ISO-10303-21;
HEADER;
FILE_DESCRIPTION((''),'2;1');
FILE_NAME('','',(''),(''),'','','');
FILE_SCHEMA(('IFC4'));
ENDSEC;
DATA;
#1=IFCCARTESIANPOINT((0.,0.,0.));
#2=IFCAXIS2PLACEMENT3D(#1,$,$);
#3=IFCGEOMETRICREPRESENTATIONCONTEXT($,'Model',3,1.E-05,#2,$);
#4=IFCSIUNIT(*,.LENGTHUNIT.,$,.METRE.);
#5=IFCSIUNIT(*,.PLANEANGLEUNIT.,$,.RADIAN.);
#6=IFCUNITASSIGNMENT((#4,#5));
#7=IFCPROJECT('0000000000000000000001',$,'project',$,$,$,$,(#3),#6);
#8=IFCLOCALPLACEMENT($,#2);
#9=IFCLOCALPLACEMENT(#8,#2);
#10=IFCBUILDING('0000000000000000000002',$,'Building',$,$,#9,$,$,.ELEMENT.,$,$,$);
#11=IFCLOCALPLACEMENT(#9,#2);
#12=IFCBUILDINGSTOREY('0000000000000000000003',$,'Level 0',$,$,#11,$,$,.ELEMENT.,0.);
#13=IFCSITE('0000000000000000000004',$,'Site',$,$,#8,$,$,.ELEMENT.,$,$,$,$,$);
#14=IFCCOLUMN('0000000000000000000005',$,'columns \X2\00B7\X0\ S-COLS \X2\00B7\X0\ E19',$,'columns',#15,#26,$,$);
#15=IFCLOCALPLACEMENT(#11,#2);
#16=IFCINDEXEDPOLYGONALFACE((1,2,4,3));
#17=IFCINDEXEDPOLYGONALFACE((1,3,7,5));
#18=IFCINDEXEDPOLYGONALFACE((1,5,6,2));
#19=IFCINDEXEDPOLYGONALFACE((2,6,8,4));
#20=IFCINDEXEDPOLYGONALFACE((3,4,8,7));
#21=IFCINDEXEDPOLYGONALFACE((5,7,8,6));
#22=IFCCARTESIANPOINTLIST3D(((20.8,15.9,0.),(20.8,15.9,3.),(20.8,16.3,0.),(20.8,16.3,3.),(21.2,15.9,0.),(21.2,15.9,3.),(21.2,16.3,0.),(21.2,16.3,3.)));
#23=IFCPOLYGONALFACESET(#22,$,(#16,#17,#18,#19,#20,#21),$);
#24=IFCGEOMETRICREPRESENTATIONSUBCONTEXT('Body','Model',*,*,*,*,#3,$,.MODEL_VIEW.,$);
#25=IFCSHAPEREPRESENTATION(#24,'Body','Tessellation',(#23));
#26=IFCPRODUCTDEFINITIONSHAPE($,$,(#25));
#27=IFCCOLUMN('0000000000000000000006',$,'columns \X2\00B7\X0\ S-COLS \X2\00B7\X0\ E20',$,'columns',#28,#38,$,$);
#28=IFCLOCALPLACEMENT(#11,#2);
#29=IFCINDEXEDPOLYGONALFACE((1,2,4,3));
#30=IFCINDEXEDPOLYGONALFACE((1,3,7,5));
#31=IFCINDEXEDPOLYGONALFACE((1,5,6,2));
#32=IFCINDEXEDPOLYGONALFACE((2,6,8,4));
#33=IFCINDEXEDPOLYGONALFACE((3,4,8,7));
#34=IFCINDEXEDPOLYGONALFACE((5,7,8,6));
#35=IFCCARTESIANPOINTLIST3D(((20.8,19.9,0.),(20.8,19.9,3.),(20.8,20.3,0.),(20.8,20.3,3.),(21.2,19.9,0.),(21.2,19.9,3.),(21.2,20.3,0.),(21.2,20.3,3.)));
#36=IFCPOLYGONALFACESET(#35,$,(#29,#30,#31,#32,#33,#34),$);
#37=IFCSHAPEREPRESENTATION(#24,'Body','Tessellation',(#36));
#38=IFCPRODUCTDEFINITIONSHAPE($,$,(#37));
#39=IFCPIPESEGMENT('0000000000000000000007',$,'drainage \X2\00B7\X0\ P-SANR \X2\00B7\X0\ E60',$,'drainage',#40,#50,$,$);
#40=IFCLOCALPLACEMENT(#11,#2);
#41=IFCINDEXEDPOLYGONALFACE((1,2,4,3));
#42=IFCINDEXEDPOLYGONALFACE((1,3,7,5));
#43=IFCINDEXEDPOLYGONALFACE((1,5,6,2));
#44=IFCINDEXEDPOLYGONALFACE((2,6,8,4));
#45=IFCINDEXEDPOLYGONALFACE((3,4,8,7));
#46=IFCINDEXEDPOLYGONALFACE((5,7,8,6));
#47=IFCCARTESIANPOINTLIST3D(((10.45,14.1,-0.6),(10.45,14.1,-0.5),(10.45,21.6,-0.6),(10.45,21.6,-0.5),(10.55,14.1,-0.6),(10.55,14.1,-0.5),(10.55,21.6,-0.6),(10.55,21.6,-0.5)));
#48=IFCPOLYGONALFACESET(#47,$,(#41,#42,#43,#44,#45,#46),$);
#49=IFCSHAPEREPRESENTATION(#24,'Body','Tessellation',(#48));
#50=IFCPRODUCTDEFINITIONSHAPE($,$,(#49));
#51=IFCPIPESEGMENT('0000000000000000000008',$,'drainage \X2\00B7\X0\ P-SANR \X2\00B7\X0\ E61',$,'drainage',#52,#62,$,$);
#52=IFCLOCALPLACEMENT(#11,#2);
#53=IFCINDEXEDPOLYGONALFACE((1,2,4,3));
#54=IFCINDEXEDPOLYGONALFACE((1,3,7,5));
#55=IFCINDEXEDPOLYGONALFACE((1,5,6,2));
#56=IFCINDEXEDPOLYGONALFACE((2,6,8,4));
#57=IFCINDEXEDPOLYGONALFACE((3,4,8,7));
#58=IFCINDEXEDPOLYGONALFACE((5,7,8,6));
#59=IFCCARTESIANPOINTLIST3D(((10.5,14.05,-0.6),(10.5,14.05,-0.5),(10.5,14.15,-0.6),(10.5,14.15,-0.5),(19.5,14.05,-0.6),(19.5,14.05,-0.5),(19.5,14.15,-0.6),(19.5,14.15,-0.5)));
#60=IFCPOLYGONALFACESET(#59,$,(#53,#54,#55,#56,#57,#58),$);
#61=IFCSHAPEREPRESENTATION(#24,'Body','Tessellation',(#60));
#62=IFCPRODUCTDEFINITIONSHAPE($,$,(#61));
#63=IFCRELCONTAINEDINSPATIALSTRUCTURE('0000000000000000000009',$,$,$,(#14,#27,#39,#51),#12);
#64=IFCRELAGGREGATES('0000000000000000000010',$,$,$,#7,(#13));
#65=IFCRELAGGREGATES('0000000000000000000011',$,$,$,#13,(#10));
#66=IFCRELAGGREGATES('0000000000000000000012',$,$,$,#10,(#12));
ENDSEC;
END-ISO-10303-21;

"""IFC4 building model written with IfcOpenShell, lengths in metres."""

from ifc_helpers import new_model, si_unit, frame, origin, place, context, subcontext, project, spatial, polyline, outline, extrude, element, save


model = new_model("IFC4")

# Units and contexts
model_context = context("Model", 3, precision=1e-05, world=origin())
body_context = subcontext(model_context, "Body", "Model", "MODEL_VIEW")
ifc_project = project(units=[si_unit("LENGTHUNIT", "METRE"), si_unit("PLANEANGLEUNIT", "RADIAN")], contexts=[model_context])

# Site, building, storey
site_placement = place(None, origin())
site = spatial("IfcSite", under=ifc_project, at=site_placement, Name="Site", CompositionType="ELEMENT")
building_placement = place(site_placement, origin())
building = spatial("IfcBuilding", under=site, at=building_placement, Name="Building", CompositionType="ELEMENT")
storey_placement = place(building_placement, origin())
storey = spatial("IfcBuildingStorey", under=building, at=storey_placement, Name="Level 0", CompositionType="ELEMENT", Elevation=0.0)

# Columns
column_1_placement = place(storey_placement, origin())
element("IfcColumn", 1, at=column_1_placement, inside=storey, Name="columns · S-COLS · E19", ObjectType="columns", context=body_context, shape_type="SweptSolid", body=[
    extrude(outline(polyline([(20.8, 15.9), (21.2, 15.9), (21.2, 16.3), (20.8, 16.3), (20.8, 15.9)])), origin(), (0.0, 0.0, 1.0), 3.0),
])
column_2_placement = place(storey_placement, origin())
element("IfcColumn", 2, at=column_2_placement, inside=storey, Name="columns · S-COLS · E20", ObjectType="columns", context=body_context, shape_type="SweptSolid", body=[
    extrude(outline(polyline([(20.8, 19.9), (21.2, 19.9), (21.2, 20.3), (20.8, 20.3), (20.8, 19.9)])), origin(), (0.0, 0.0, 1.0), 3.0),
])

# Pipe segments
pipe_segment_1_placement = place(storey_placement, frame((0.0, 0.0, -0.6)))
element("IfcPipeSegment", 3, at=pipe_segment_1_placement, inside=storey, Name="drainage · P-SANR · E60", ObjectType="drainage", context=body_context, shape_type="SweptSolid", body=[
    extrude(outline(polyline([(10.45, 21.6), (10.45, 14.1), (10.55, 14.1), (10.55, 21.6), (10.45, 21.6)])), origin(), (0.0, 0.0, 1.0), 0.1),
])
pipe_segment_2_placement = place(storey_placement, frame((0.0, 0.0, -0.6)))
element("IfcPipeSegment", 4, at=pipe_segment_2_placement, inside=storey, Name="drainage · P-SANR · E61", ObjectType="drainage", context=body_context, shape_type="SweptSolid", body=[
    extrude(outline(polyline([(10.5, 14.05), (19.5, 14.05), (19.5, 14.15), (10.5, 14.15), (10.5, 14.05)])), origin(), (0.0, 0.0, 1.0), 0.1),
])

save(model, "model.ifc")
